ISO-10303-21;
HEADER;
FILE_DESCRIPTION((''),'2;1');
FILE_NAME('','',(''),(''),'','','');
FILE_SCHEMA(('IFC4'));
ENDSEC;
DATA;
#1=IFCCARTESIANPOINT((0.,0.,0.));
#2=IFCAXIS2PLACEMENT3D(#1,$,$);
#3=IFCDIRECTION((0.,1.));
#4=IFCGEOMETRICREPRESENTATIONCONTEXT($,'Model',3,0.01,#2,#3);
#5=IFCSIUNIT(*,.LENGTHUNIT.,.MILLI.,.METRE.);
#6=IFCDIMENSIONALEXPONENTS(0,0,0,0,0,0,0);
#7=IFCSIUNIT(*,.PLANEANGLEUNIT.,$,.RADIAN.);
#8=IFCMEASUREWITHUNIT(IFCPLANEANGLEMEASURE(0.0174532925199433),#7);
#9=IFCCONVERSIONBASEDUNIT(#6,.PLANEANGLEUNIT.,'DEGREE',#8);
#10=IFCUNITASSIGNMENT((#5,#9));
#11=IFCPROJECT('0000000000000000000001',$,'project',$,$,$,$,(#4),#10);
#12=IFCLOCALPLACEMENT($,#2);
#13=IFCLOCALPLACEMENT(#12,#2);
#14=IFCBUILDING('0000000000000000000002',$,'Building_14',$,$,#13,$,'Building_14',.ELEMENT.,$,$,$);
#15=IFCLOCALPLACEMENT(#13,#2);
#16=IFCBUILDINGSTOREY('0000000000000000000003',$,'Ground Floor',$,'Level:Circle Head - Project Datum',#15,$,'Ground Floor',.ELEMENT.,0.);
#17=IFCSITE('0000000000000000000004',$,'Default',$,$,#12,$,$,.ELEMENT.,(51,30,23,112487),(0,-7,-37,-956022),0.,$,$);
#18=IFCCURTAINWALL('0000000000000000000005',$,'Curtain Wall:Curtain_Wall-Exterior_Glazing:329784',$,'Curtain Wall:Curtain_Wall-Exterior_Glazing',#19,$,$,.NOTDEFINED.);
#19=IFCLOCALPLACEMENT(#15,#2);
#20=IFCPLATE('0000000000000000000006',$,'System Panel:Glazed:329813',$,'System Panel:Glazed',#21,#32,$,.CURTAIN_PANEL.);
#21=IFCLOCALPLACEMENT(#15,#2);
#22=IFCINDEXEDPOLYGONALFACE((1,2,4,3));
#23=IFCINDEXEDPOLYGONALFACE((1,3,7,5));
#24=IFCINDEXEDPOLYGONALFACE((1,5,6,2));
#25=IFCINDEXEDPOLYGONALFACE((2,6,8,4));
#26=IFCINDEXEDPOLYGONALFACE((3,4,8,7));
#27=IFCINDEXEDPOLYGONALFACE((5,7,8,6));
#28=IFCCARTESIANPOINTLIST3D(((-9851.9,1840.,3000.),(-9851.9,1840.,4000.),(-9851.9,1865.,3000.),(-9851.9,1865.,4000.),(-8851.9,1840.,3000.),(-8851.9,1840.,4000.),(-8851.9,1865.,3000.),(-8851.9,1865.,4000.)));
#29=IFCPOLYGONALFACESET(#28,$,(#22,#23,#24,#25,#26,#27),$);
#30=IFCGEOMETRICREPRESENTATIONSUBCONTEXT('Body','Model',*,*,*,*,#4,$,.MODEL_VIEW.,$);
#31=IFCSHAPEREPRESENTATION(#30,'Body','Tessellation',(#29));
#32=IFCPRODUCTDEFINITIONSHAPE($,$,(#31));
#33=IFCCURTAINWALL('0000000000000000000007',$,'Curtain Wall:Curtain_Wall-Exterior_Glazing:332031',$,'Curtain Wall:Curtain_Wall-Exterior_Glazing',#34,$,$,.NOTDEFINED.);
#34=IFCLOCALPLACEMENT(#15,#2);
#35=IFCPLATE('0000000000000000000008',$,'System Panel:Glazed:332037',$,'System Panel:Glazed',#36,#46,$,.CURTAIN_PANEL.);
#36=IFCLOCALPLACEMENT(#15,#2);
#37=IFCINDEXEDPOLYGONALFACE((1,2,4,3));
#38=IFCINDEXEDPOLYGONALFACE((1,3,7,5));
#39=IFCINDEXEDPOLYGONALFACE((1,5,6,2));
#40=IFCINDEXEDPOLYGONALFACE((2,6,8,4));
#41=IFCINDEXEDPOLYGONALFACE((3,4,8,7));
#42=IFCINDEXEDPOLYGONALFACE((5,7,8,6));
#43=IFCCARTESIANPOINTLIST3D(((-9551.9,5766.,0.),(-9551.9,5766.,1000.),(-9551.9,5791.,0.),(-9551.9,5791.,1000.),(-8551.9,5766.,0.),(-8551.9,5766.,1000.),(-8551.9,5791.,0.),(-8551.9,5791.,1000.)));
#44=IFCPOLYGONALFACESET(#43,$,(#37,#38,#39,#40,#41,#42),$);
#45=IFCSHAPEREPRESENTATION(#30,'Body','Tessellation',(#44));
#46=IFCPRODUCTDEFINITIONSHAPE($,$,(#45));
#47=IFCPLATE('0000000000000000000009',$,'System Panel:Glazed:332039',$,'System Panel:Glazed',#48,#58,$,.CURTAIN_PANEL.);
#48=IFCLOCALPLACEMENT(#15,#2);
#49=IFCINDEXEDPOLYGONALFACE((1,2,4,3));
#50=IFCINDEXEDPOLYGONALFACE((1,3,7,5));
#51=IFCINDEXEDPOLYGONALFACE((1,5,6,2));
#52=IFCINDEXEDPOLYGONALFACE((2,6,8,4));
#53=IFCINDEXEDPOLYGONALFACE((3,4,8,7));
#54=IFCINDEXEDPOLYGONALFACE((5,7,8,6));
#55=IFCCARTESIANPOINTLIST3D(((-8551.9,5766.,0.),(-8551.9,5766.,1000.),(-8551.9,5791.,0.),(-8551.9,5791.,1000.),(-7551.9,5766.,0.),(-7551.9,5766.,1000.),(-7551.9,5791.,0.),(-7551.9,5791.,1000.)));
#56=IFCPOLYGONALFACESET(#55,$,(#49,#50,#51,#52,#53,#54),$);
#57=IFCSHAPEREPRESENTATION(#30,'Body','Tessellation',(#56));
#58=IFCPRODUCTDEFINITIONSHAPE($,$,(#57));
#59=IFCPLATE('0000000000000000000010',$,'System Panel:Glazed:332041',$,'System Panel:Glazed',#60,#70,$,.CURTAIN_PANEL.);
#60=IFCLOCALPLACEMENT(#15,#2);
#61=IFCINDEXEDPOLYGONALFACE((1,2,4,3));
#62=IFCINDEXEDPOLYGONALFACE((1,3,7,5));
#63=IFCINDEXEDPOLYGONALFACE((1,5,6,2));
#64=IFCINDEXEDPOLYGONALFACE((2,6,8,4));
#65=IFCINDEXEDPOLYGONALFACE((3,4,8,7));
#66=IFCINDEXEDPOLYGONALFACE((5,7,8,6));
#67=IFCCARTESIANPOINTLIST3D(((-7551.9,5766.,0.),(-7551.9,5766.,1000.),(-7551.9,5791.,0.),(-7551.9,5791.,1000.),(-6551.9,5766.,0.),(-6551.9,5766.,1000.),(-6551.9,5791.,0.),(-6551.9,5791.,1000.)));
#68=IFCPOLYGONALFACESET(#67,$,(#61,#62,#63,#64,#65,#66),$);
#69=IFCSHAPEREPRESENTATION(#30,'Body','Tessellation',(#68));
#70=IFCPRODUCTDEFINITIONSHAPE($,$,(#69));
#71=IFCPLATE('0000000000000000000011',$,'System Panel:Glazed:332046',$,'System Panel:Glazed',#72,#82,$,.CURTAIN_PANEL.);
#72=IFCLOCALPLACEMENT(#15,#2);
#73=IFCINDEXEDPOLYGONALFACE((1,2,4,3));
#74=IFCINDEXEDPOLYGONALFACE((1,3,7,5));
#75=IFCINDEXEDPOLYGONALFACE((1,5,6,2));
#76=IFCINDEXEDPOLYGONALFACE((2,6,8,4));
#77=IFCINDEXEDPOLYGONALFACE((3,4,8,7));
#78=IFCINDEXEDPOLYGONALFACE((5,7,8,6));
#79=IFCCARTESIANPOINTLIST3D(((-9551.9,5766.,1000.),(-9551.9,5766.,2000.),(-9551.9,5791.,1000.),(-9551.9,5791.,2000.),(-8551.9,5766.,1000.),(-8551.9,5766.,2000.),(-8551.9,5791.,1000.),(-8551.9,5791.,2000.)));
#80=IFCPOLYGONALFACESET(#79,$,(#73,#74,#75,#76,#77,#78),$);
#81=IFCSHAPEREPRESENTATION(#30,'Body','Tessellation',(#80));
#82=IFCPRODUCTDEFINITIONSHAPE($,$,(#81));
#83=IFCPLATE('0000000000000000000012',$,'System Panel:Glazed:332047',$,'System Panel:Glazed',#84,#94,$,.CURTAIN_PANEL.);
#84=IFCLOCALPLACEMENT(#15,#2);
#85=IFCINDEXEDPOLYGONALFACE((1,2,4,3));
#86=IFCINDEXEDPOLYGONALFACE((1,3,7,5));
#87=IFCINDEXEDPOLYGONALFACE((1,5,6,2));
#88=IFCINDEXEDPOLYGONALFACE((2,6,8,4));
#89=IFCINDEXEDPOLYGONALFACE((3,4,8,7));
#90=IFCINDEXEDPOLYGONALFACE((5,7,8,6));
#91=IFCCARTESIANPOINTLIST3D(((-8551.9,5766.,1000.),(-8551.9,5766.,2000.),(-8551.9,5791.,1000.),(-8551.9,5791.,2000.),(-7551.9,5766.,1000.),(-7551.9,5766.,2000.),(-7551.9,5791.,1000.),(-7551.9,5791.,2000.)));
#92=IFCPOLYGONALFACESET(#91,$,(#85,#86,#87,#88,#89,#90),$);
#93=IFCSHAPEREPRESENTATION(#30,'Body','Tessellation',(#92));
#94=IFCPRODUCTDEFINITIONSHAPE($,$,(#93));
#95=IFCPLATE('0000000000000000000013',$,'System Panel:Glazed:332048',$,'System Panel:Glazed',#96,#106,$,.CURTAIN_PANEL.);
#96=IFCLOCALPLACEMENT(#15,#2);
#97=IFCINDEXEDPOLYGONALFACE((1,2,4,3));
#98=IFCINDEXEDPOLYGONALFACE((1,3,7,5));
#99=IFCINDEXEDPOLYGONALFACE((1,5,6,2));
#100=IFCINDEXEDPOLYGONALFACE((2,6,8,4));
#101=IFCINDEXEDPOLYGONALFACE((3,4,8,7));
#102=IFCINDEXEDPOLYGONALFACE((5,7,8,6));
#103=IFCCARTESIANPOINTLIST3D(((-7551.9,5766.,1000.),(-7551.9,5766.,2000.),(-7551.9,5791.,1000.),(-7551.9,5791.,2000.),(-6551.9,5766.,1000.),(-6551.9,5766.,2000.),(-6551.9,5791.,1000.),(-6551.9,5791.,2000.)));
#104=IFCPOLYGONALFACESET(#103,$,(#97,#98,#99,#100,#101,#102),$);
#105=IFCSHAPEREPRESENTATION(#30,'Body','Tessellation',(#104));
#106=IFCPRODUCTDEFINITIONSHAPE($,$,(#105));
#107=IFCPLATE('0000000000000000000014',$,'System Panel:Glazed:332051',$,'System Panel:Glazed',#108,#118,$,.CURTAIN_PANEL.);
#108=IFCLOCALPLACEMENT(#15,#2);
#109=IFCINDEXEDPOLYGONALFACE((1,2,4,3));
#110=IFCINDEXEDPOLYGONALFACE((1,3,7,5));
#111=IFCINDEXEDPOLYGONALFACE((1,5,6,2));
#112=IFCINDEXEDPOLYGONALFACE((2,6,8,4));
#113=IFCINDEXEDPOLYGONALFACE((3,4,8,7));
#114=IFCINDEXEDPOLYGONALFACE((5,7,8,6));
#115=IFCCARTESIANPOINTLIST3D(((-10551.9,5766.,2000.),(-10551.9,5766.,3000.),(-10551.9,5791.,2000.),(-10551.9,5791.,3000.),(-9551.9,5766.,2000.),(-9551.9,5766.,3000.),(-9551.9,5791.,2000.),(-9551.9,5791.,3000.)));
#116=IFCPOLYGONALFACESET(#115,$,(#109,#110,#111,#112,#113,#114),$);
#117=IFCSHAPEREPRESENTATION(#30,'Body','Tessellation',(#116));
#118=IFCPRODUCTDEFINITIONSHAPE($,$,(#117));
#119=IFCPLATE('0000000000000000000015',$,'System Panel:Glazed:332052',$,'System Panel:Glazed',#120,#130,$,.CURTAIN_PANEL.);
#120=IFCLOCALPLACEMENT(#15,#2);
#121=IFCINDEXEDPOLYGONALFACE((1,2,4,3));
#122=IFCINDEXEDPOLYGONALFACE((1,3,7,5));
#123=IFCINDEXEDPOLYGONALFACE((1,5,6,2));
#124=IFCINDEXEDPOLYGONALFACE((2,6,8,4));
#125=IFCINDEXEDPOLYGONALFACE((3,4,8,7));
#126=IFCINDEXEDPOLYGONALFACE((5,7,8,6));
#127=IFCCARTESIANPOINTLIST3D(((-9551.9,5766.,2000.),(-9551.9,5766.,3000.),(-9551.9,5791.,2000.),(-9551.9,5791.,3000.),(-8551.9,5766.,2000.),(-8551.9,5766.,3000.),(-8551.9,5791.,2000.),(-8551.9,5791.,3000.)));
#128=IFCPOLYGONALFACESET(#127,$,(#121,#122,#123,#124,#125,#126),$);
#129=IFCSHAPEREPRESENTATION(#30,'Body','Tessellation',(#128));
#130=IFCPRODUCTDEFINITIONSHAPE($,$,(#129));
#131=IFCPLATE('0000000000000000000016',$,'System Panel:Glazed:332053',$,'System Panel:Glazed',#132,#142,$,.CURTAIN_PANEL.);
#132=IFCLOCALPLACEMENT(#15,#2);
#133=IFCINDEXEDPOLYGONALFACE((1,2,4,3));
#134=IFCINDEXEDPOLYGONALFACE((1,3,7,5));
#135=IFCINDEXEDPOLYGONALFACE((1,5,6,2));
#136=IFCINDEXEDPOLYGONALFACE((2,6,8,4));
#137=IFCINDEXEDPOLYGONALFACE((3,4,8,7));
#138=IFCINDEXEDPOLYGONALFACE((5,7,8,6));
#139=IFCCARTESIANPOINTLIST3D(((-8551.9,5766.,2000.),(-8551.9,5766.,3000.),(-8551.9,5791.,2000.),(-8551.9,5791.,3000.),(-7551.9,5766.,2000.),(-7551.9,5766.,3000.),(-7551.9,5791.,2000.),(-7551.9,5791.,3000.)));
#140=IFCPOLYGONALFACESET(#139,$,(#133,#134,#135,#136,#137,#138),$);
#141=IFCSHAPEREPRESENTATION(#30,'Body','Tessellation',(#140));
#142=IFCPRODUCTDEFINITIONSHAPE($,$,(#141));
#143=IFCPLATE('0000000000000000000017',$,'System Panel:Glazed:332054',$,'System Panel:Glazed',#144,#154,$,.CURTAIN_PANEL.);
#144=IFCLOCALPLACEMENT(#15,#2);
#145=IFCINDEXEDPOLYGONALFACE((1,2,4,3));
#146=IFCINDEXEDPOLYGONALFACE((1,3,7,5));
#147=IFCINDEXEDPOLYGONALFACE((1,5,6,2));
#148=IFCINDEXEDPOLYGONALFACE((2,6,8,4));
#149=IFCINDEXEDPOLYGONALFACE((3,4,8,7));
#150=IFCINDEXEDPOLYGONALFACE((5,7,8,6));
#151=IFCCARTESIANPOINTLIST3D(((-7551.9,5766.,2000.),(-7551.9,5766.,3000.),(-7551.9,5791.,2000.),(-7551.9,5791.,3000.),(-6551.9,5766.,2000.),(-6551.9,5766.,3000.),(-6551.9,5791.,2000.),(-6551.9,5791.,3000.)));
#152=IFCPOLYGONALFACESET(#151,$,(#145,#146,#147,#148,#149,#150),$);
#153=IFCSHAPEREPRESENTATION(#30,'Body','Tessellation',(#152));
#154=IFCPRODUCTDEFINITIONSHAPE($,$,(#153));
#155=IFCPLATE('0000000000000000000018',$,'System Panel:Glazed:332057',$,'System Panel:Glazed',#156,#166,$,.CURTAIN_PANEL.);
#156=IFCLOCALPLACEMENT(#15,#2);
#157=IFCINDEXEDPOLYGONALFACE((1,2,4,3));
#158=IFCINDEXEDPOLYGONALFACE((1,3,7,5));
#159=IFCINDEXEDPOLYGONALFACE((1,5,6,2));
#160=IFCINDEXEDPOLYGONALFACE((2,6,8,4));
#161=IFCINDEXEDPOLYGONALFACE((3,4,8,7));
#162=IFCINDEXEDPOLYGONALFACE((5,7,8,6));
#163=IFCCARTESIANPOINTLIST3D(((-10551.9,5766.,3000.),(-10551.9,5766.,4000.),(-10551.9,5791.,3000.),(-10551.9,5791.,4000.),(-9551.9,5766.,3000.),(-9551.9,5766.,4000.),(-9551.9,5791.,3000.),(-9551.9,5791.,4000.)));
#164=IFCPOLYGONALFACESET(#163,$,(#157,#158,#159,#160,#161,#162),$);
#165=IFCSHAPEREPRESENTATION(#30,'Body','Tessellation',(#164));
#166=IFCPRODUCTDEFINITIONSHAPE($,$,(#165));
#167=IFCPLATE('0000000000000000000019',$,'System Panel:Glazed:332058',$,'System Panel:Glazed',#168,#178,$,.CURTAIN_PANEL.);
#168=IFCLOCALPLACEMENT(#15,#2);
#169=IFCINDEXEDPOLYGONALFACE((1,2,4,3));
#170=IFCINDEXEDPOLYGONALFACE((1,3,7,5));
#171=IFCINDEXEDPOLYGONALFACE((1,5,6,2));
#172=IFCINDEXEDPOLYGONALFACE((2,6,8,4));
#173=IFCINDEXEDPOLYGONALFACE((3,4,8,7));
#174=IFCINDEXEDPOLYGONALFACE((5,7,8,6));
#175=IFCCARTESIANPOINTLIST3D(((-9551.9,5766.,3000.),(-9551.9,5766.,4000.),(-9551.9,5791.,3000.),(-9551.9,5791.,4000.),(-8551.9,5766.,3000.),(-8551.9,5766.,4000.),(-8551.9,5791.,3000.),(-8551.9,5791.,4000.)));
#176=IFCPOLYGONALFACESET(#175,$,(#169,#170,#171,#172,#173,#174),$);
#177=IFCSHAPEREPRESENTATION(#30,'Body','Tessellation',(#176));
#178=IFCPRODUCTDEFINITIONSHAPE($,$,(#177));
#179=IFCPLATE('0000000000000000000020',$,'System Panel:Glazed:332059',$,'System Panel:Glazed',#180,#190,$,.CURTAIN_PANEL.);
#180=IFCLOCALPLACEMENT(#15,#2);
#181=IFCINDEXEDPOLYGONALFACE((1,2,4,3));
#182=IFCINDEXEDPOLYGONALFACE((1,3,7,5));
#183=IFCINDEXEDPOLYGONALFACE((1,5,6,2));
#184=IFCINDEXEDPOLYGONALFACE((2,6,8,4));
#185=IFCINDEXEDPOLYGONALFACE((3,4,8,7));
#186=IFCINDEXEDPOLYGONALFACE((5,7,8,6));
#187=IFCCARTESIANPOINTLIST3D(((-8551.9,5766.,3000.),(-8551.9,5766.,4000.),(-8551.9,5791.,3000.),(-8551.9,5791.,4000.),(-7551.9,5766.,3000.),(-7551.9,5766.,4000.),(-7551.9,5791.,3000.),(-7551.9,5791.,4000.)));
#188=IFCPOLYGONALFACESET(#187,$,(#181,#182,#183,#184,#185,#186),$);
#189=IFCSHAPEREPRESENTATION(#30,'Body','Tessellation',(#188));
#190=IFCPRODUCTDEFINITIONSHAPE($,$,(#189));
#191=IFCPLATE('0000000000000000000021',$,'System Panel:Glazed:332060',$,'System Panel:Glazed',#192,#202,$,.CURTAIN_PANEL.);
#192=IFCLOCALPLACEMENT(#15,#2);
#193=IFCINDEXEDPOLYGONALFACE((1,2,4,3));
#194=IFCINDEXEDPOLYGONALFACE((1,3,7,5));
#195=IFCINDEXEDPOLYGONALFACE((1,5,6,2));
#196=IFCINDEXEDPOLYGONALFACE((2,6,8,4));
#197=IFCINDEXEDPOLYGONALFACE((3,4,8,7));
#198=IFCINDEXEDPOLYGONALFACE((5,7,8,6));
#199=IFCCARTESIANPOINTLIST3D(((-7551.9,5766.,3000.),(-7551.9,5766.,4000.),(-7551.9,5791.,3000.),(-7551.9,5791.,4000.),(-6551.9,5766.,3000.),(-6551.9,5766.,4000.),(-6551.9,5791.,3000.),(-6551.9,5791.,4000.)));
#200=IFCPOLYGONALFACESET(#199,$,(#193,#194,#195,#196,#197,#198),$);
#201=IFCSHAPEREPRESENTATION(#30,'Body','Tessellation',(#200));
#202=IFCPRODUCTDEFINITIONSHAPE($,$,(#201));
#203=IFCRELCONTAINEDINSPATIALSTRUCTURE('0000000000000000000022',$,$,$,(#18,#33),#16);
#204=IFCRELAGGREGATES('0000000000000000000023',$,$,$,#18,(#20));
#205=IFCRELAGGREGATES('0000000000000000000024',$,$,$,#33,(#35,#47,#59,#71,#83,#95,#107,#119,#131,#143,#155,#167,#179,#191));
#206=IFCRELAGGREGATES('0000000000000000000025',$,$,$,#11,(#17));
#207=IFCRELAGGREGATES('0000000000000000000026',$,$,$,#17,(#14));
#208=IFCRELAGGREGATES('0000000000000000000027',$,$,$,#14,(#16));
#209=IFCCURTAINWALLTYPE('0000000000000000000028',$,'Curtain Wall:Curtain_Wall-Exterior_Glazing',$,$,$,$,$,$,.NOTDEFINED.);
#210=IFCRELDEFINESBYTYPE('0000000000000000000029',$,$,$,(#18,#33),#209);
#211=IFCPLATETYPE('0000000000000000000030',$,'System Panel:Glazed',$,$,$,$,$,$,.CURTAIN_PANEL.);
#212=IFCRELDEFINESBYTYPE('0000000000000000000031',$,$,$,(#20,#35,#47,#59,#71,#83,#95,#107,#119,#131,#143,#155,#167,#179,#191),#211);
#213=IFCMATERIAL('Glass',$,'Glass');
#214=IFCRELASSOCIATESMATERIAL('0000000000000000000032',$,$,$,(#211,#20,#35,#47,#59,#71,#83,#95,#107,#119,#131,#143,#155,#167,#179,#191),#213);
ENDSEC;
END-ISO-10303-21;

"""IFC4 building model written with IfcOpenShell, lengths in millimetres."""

from ifc_helpers import new_model, entity, si_unit, converted_unit, direction, frame, origin, place, context, subcontext, project, spatial, indexed_curve, outline, extrude, source, transform, mapped, material, type_object, type_shapes, element, aggregate, save


model = new_model("IFC4")

# Units and contexts
model_context = context("Model", 3, precision=0.01, world=origin(), true_north=direction((0.0, 1.0)))
body_context = subcontext(model_context, "Body", "Model", "MODEL_VIEW")
ifc_project = project(units=[si_unit("LENGTHUNIT", "METRE", prefix="MILLI"), converted_unit("PLANEANGLEUNIT", "DEGREE", entity("IfcPlaneAngleMeasure", 0.0174532925199433), si_unit("PLANEANGLEUNIT", "RADIAN"), dimensions=[0, 0, 0, 0, 0, 0, 0])], contexts=[model_context])

# Site, building, storey
site_placement = place(None, origin())
site = spatial("IfcSite", under=ifc_project, at=site_placement, Name="Default", CompositionType="ELEMENT", RefLatitude=(51, 30, 23, 112487), RefLongitude=(0, -7, -37, -956022), RefElevation=0.0)
building_placement = place(site_placement, origin())
building = spatial("IfcBuilding", under=site, at=building_placement, Name="Building_14", LongName="Building_14", CompositionType="ELEMENT")
storey_placement = place(building_placement, origin())
storey = spatial("IfcBuildingStorey", under=building, at=storey_placement, Name="Ground Floor", ObjectType="Level:Circle Head - Project Datum", LongName="Ground Floor", CompositionType="ELEMENT", Elevation=0.0)

# Curtain walls, plates
curtain_wall_type = type_object("IfcCurtainWallType", Name="Curtain Wall:Curtain_Wall-Exterior_Glazing", PredefinedType="NOTDEFINED")
curtain_wall_1_placement = place(storey_placement, origin())
curtain_wall_1 = element("IfcCurtainWall", 1, at=curtain_wall_1_placement, inside=storey, type_object=curtain_wall_type, Name="Curtain Wall:Curtain_Wall-Exterior_Glazing:329784", ObjectType="Curtain Wall:Curtain_Wall-Exterior_Glazing", PredefinedType="NOTDEFINED")
ifc_material = material(Name="Glass", Category="Glass")
plate_type_1 = type_object("IfcPlateType", Name="System Panel:Glazed", PredefinedType="CURTAIN_PANEL", material=ifc_material)
shared_shape_1 = source(origin(), body_context, "Body", "SweptSolid", [
    extrude(outline(indexed_curve([(-12.5, -500.0), (12.5, -500.0), (12.5, 500.0), (-12.5, 500.0), (-12.5, -500.0)], self_intersect=False)), frame((0.0, -37.0, 0.0), z_axis=(0.0, 0.0, 1.0), x_axis=(0.0, 1.0, 0.0)), (0.0, 0.0, 1.0), 1000.0),
])
type_shapes(plate_type_1, [shared_shape_1])
plate_1_placement = place(curtain_wall_1_placement, frame((-9351.9, 1815.5, 3000.0), z_axis=(0.0, 0.0, 1.0), x_axis=(-1.0, 0.0, 0.0)))
plate_1 = element("IfcPlate", 2, at=plate_1_placement, type_object=plate_type_1, material=ifc_material, Name="System Panel:Glazed:329813", ObjectType="System Panel:Glazed", PredefinedType="CURTAIN_PANEL", context=body_context, shape_type="MappedRepresentation", body=[
    mapped(shared_shape_1, transform((0.0, 0.0, 0.0), scale=1.0)),
])
aggregate(curtain_wall_1, [plate_1])
curtain_wall_2_placement = place(storey_placement, origin())
curtain_wall_2 = element("IfcCurtainWall", 3, at=curtain_wall_2_placement, inside=storey, type_object=curtain_wall_type, Name="Curtain Wall:Curtain_Wall-Exterior_Glazing:332031", ObjectType="Curtain Wall:Curtain_Wall-Exterior_Glazing", PredefinedType="NOTDEFINED")
plate_2_placement = place(curtain_wall_2_placement, frame((-9051.9, 5815.5, 0.0)))
plate_2 = element("IfcPlate", 4, at=plate_2_placement, type_object=plate_type_1, material=ifc_material, Name="System Panel:Glazed:332037", ObjectType="System Panel:Glazed", PredefinedType="CURTAIN_PANEL", context=body_context, shape_type="MappedRepresentation", body=[
    mapped(shared_shape_1, transform((0.0, 0.0, 0.0), scale=1.0)),
])
plate_3_placement = place(curtain_wall_2_placement, frame((-8051.9, 5815.5, 0.0)))
plate_3 = element("IfcPlate", 5, at=plate_3_placement, type_object=plate_type_1, material=ifc_material, Name="System Panel:Glazed:332039", ObjectType="System Panel:Glazed", PredefinedType="CURTAIN_PANEL", context=body_context, shape_type="MappedRepresentation", body=[
    mapped(shared_shape_1, transform((0.0, 0.0, 0.0), scale=1.0)),
])
plate_4_placement = place(curtain_wall_2_placement, frame((-7051.9, 5815.5, 0.0)))
plate_4 = element("IfcPlate", 6, at=plate_4_placement, type_object=plate_type_1, material=ifc_material, Name="System Panel:Glazed:332041", ObjectType="System Panel:Glazed", PredefinedType="CURTAIN_PANEL", context=body_context, shape_type="MappedRepresentation", body=[
    mapped(shared_shape_1, transform((0.0, 0.0, 0.0), scale=1.0)),
])
plate_5_placement = place(curtain_wall_2_placement, frame((-9051.9, 5815.5, 1000.0)))
plate_5 = element("IfcPlate", 7, at=plate_5_placement, type_object=plate_type_1, material=ifc_material, Name="System Panel:Glazed:332046", ObjectType="System Panel:Glazed", PredefinedType="CURTAIN_PANEL", context=body_context, shape_type="MappedRepresentation", body=[
    mapped(shared_shape_1, transform((0.0, 0.0, 0.0), scale=1.0)),
])
plate_6_placement = place(curtain_wall_2_placement, frame((-8051.9, 5815.5, 1000.0)))
plate_6 = element("IfcPlate", 8, at=plate_6_placement, type_object=plate_type_1, material=ifc_material, Name="System Panel:Glazed:332047", ObjectType="System Panel:Glazed", PredefinedType="CURTAIN_PANEL", context=body_context, shape_type="MappedRepresentation", body=[
    mapped(shared_shape_1, transform((0.0, 0.0, 0.0), scale=1.0)),
])
plate_7_placement = place(curtain_wall_2_placement, frame((-7051.9, 5815.5, 1000.0)))
plate_7 = element("IfcPlate", 9, at=plate_7_placement, type_object=plate_type_1, material=ifc_material, Name="System Panel:Glazed:332048", ObjectType="System Panel:Glazed", PredefinedType="CURTAIN_PANEL", context=body_context, shape_type="MappedRepresentation", body=[
    mapped(shared_shape_1, transform((0.0, 0.0, 0.0), scale=1.0)),
])
plate_8_placement = place(curtain_wall_2_placement, frame((-10051.9, 5815.5, 2000.0)))
plate_8 = element("IfcPlate", 10, at=plate_8_placement, type_object=plate_type_1, material=ifc_material, Name="System Panel:Glazed:332051", ObjectType="System Panel:Glazed", PredefinedType="CURTAIN_PANEL", context=body_context, shape_type="MappedRepresentation", body=[
    mapped(shared_shape_1, transform((0.0, 0.0, 0.0), scale=1.0)),
])
plate_9_placement = place(curtain_wall_2_placement, frame((-9051.9, 5815.5, 2000.0)))
plate_9 = element("IfcPlate", 11, at=plate_9_placement, type_object=plate_type_1, material=ifc_material, Name="System Panel:Glazed:332052", ObjectType="System Panel:Glazed", PredefinedType="CURTAIN_PANEL", context=body_context, shape_type="MappedRepresentation", body=[
    mapped(shared_shape_1, transform((0.0, 0.0, 0.0), scale=1.0)),
])
plate_10_placement = place(curtain_wall_2_placement, frame((-8051.9, 5815.5, 2000.0)))
plate_10 = element("IfcPlate", 12, at=plate_10_placement, type_object=plate_type_1, material=ifc_material, Name="System Panel:Glazed:332053", ObjectType="System Panel:Glazed", PredefinedType="CURTAIN_PANEL", context=body_context, shape_type="MappedRepresentation", body=[
    mapped(shared_shape_1, transform((0.0, 0.0, 0.0), scale=1.0)),
])
plate_11_placement = place(curtain_wall_2_placement, frame((-7051.9, 5815.5, 2000.0)))
plate_11 = element("IfcPlate", 13, at=plate_11_placement, type_object=plate_type_1, material=ifc_material, Name="System Panel:Glazed:332054", ObjectType="System Panel:Glazed", PredefinedType="CURTAIN_PANEL", context=body_context, shape_type="MappedRepresentation", body=[
    mapped(shared_shape_1, transform((0.0, 0.0, 0.0), scale=1.0)),
])
plate_12_placement = place(curtain_wall_2_placement, frame((-10051.9, 5815.5, 3000.0)))
plate_12 = element("IfcPlate", 14, at=plate_12_placement, type_object=plate_type_1, material=ifc_material, Name="System Panel:Glazed:332057", ObjectType="System Panel:Glazed", PredefinedType="CURTAIN_PANEL", context=body_context, shape_type="MappedRepresentation", body=[
    mapped(shared_shape_1, transform((0.0, 0.0, 0.0), scale=1.0)),
])
plate_13_placement = place(curtain_wall_2_placement, frame((-9051.9, 5815.5, 3000.0)))
plate_13 = element("IfcPlate", 15, at=plate_13_placement, type_object=plate_type_1, material=ifc_material, Name="System Panel:Glazed:332058", ObjectType="System Panel:Glazed", PredefinedType="CURTAIN_PANEL", context=body_context, shape_type="MappedRepresentation", body=[
    mapped(shared_shape_1, transform((0.0, 0.0, 0.0), scale=1.0)),
])
plate_14_placement = place(curtain_wall_2_placement, frame((-8051.9, 5815.5, 3000.0)))
plate_14 = element("IfcPlate", 16, at=plate_14_placement, type_object=plate_type_1, material=ifc_material, Name="System Panel:Glazed:332059", ObjectType="System Panel:Glazed", PredefinedType="CURTAIN_PANEL", context=body_context, shape_type="MappedRepresentation", body=[
    mapped(shared_shape_1, transform((0.0, 0.0, 0.0), scale=1.0)),
])
plate_15_placement = place(curtain_wall_2_placement, frame((-7051.9, 5815.5, 3000.0)))
plate_15 = element("IfcPlate", 17, at=plate_15_placement, type_object=plate_type_1, material=ifc_material, Name="System Panel:Glazed:332060", ObjectType="System Panel:Glazed", PredefinedType="CURTAIN_PANEL", context=body_context, shape_type="MappedRepresentation", body=[
    mapped(shared_shape_1, transform((0.0, 0.0, 0.0), scale=1.0)),
])
aggregate(curtain_wall_2, [plate_2, plate_3, plate_4, plate_5, plate_6, plate_7, plate_8, plate_9, plate_10, plate_11, plate_12, plate_13, plate_14, plate_15])

save(model, "model.ifc")
